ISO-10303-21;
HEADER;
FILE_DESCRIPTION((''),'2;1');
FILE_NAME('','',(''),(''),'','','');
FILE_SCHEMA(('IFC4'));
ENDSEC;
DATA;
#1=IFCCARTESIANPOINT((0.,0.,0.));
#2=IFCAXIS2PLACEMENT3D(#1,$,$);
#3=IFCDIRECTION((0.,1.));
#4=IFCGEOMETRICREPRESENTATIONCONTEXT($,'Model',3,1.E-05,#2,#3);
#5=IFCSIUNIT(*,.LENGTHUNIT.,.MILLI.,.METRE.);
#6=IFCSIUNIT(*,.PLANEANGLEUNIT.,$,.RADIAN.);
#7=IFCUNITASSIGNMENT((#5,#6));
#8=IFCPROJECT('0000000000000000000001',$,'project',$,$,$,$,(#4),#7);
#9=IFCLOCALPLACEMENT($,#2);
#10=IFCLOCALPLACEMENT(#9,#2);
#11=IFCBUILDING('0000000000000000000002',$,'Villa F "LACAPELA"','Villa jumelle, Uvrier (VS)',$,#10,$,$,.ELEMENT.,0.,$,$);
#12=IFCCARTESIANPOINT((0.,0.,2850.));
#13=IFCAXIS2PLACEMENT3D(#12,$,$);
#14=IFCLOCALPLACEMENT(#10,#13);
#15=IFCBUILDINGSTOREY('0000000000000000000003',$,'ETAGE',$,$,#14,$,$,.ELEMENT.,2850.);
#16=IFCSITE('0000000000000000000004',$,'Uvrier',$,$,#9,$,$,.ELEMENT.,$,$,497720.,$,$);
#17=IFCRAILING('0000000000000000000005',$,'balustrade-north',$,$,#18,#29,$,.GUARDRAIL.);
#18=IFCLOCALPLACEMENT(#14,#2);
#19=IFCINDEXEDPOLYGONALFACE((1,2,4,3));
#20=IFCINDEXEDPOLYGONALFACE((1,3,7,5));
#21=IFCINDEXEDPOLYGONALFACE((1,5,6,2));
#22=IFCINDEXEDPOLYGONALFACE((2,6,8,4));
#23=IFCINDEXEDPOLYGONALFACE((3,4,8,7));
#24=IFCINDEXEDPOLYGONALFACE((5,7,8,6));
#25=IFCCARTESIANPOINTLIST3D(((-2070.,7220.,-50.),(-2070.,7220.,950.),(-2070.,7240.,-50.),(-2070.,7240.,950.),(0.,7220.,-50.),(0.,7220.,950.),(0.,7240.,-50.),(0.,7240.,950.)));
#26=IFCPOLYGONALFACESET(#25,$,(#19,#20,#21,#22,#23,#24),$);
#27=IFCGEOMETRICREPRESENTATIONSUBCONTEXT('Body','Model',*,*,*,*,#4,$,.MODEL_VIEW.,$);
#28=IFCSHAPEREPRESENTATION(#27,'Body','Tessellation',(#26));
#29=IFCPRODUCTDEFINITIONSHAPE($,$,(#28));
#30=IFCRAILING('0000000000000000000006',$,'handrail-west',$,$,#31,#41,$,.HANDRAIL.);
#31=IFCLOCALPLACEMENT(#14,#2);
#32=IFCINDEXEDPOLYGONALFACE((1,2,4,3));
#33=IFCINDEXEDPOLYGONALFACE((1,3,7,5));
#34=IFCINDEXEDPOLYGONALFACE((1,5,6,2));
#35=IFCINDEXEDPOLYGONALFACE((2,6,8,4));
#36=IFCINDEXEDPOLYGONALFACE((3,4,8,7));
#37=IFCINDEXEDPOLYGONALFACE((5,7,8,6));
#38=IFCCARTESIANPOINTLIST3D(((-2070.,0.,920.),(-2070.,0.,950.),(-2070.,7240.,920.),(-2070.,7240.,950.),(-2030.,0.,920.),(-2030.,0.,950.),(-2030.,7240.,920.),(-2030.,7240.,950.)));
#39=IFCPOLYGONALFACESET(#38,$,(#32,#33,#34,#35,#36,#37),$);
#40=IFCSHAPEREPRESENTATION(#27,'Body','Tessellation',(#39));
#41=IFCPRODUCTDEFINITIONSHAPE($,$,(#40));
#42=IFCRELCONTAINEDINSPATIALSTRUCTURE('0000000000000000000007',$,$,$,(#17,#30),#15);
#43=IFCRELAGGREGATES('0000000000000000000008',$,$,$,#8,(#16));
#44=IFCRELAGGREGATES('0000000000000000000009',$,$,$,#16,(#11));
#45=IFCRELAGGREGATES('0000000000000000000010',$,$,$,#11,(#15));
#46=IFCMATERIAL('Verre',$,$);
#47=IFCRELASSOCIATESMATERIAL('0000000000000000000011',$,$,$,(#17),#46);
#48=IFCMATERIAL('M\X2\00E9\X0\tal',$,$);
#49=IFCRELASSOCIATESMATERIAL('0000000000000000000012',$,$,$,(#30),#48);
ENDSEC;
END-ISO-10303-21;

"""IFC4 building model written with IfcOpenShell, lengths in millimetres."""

from ifc_helpers import new_model, si_unit, direction, frame, frame_2d, origin, place, context, subcontext, project, spatial, rectangle, extrude, material, element, save


model = new_model("IFC4")

# Units and contexts
model_context = context("Model", 3, precision=1e-05, world=origin(), true_north=direction((0.0, 1.0)))
body_context = subcontext(model_context, "Body", "Model", "MODEL_VIEW")
ifc_project = project(units=[si_unit("LENGTHUNIT", "METRE", prefix="MILLI"), si_unit("PLANEANGLEUNIT", "RADIAN")], contexts=[model_context])

# Site, building, storey
site_placement = place(None, origin())
site = spatial("IfcSite", under=ifc_project, at=site_placement, Name="Uvrier", CompositionType="ELEMENT", RefElevation=497720.0)
building_placement = place(site_placement, origin())
building = spatial("IfcBuilding", under=site, at=building_placement, Name="Villa F \"LACAPELA\"", Description="Villa jumelle, Uvrier (VS)", CompositionType="ELEMENT", ElevationOfRefHeight=0.0)
storey_placement = place(building_placement, frame((0.0, 0.0, 2850.0)))
storey = spatial("IfcBuildingStorey", under=building, at=storey_placement, Name="ETAGE", CompositionType="ELEMENT", Elevation=2850.0)

# Railings
ifc_material_1 = material(Name="Verre")
railing_1_placement = place(storey_placement, origin())
element("IfcRailing", 1, at=railing_1_placement, inside=storey, material=ifc_material_1, Name="balustrade-north", PredefinedType="GUARDRAIL", context=body_context, shape_type="SweptSolid", body=[
    extrude(rectangle(XDim=2070.0, YDim=20.0, at=frame_2d((-1035.0, 7230.0))), frame((0.0, 0.0, -50.0)), (0.0, 0.0, 1.0), 1000.0),
])
ifc_material_2 = material(Name="Métal")
railing_2_placement = place(storey_placement, origin())
element("IfcRailing", 2, at=railing_2_placement, inside=storey, material=ifc_material_2, Name="handrail-west", PredefinedType="HANDRAIL", context=body_context, shape_type="SweptSolid", body=[
    extrude(rectangle(XDim=40.0, YDim=7240.0, at=frame_2d((-2050.0, 3620.0))), frame((0.0, 0.0, 920.0)), (0.0, 0.0, 1.0), 30.0),
])

save(model, "model.ifc")
